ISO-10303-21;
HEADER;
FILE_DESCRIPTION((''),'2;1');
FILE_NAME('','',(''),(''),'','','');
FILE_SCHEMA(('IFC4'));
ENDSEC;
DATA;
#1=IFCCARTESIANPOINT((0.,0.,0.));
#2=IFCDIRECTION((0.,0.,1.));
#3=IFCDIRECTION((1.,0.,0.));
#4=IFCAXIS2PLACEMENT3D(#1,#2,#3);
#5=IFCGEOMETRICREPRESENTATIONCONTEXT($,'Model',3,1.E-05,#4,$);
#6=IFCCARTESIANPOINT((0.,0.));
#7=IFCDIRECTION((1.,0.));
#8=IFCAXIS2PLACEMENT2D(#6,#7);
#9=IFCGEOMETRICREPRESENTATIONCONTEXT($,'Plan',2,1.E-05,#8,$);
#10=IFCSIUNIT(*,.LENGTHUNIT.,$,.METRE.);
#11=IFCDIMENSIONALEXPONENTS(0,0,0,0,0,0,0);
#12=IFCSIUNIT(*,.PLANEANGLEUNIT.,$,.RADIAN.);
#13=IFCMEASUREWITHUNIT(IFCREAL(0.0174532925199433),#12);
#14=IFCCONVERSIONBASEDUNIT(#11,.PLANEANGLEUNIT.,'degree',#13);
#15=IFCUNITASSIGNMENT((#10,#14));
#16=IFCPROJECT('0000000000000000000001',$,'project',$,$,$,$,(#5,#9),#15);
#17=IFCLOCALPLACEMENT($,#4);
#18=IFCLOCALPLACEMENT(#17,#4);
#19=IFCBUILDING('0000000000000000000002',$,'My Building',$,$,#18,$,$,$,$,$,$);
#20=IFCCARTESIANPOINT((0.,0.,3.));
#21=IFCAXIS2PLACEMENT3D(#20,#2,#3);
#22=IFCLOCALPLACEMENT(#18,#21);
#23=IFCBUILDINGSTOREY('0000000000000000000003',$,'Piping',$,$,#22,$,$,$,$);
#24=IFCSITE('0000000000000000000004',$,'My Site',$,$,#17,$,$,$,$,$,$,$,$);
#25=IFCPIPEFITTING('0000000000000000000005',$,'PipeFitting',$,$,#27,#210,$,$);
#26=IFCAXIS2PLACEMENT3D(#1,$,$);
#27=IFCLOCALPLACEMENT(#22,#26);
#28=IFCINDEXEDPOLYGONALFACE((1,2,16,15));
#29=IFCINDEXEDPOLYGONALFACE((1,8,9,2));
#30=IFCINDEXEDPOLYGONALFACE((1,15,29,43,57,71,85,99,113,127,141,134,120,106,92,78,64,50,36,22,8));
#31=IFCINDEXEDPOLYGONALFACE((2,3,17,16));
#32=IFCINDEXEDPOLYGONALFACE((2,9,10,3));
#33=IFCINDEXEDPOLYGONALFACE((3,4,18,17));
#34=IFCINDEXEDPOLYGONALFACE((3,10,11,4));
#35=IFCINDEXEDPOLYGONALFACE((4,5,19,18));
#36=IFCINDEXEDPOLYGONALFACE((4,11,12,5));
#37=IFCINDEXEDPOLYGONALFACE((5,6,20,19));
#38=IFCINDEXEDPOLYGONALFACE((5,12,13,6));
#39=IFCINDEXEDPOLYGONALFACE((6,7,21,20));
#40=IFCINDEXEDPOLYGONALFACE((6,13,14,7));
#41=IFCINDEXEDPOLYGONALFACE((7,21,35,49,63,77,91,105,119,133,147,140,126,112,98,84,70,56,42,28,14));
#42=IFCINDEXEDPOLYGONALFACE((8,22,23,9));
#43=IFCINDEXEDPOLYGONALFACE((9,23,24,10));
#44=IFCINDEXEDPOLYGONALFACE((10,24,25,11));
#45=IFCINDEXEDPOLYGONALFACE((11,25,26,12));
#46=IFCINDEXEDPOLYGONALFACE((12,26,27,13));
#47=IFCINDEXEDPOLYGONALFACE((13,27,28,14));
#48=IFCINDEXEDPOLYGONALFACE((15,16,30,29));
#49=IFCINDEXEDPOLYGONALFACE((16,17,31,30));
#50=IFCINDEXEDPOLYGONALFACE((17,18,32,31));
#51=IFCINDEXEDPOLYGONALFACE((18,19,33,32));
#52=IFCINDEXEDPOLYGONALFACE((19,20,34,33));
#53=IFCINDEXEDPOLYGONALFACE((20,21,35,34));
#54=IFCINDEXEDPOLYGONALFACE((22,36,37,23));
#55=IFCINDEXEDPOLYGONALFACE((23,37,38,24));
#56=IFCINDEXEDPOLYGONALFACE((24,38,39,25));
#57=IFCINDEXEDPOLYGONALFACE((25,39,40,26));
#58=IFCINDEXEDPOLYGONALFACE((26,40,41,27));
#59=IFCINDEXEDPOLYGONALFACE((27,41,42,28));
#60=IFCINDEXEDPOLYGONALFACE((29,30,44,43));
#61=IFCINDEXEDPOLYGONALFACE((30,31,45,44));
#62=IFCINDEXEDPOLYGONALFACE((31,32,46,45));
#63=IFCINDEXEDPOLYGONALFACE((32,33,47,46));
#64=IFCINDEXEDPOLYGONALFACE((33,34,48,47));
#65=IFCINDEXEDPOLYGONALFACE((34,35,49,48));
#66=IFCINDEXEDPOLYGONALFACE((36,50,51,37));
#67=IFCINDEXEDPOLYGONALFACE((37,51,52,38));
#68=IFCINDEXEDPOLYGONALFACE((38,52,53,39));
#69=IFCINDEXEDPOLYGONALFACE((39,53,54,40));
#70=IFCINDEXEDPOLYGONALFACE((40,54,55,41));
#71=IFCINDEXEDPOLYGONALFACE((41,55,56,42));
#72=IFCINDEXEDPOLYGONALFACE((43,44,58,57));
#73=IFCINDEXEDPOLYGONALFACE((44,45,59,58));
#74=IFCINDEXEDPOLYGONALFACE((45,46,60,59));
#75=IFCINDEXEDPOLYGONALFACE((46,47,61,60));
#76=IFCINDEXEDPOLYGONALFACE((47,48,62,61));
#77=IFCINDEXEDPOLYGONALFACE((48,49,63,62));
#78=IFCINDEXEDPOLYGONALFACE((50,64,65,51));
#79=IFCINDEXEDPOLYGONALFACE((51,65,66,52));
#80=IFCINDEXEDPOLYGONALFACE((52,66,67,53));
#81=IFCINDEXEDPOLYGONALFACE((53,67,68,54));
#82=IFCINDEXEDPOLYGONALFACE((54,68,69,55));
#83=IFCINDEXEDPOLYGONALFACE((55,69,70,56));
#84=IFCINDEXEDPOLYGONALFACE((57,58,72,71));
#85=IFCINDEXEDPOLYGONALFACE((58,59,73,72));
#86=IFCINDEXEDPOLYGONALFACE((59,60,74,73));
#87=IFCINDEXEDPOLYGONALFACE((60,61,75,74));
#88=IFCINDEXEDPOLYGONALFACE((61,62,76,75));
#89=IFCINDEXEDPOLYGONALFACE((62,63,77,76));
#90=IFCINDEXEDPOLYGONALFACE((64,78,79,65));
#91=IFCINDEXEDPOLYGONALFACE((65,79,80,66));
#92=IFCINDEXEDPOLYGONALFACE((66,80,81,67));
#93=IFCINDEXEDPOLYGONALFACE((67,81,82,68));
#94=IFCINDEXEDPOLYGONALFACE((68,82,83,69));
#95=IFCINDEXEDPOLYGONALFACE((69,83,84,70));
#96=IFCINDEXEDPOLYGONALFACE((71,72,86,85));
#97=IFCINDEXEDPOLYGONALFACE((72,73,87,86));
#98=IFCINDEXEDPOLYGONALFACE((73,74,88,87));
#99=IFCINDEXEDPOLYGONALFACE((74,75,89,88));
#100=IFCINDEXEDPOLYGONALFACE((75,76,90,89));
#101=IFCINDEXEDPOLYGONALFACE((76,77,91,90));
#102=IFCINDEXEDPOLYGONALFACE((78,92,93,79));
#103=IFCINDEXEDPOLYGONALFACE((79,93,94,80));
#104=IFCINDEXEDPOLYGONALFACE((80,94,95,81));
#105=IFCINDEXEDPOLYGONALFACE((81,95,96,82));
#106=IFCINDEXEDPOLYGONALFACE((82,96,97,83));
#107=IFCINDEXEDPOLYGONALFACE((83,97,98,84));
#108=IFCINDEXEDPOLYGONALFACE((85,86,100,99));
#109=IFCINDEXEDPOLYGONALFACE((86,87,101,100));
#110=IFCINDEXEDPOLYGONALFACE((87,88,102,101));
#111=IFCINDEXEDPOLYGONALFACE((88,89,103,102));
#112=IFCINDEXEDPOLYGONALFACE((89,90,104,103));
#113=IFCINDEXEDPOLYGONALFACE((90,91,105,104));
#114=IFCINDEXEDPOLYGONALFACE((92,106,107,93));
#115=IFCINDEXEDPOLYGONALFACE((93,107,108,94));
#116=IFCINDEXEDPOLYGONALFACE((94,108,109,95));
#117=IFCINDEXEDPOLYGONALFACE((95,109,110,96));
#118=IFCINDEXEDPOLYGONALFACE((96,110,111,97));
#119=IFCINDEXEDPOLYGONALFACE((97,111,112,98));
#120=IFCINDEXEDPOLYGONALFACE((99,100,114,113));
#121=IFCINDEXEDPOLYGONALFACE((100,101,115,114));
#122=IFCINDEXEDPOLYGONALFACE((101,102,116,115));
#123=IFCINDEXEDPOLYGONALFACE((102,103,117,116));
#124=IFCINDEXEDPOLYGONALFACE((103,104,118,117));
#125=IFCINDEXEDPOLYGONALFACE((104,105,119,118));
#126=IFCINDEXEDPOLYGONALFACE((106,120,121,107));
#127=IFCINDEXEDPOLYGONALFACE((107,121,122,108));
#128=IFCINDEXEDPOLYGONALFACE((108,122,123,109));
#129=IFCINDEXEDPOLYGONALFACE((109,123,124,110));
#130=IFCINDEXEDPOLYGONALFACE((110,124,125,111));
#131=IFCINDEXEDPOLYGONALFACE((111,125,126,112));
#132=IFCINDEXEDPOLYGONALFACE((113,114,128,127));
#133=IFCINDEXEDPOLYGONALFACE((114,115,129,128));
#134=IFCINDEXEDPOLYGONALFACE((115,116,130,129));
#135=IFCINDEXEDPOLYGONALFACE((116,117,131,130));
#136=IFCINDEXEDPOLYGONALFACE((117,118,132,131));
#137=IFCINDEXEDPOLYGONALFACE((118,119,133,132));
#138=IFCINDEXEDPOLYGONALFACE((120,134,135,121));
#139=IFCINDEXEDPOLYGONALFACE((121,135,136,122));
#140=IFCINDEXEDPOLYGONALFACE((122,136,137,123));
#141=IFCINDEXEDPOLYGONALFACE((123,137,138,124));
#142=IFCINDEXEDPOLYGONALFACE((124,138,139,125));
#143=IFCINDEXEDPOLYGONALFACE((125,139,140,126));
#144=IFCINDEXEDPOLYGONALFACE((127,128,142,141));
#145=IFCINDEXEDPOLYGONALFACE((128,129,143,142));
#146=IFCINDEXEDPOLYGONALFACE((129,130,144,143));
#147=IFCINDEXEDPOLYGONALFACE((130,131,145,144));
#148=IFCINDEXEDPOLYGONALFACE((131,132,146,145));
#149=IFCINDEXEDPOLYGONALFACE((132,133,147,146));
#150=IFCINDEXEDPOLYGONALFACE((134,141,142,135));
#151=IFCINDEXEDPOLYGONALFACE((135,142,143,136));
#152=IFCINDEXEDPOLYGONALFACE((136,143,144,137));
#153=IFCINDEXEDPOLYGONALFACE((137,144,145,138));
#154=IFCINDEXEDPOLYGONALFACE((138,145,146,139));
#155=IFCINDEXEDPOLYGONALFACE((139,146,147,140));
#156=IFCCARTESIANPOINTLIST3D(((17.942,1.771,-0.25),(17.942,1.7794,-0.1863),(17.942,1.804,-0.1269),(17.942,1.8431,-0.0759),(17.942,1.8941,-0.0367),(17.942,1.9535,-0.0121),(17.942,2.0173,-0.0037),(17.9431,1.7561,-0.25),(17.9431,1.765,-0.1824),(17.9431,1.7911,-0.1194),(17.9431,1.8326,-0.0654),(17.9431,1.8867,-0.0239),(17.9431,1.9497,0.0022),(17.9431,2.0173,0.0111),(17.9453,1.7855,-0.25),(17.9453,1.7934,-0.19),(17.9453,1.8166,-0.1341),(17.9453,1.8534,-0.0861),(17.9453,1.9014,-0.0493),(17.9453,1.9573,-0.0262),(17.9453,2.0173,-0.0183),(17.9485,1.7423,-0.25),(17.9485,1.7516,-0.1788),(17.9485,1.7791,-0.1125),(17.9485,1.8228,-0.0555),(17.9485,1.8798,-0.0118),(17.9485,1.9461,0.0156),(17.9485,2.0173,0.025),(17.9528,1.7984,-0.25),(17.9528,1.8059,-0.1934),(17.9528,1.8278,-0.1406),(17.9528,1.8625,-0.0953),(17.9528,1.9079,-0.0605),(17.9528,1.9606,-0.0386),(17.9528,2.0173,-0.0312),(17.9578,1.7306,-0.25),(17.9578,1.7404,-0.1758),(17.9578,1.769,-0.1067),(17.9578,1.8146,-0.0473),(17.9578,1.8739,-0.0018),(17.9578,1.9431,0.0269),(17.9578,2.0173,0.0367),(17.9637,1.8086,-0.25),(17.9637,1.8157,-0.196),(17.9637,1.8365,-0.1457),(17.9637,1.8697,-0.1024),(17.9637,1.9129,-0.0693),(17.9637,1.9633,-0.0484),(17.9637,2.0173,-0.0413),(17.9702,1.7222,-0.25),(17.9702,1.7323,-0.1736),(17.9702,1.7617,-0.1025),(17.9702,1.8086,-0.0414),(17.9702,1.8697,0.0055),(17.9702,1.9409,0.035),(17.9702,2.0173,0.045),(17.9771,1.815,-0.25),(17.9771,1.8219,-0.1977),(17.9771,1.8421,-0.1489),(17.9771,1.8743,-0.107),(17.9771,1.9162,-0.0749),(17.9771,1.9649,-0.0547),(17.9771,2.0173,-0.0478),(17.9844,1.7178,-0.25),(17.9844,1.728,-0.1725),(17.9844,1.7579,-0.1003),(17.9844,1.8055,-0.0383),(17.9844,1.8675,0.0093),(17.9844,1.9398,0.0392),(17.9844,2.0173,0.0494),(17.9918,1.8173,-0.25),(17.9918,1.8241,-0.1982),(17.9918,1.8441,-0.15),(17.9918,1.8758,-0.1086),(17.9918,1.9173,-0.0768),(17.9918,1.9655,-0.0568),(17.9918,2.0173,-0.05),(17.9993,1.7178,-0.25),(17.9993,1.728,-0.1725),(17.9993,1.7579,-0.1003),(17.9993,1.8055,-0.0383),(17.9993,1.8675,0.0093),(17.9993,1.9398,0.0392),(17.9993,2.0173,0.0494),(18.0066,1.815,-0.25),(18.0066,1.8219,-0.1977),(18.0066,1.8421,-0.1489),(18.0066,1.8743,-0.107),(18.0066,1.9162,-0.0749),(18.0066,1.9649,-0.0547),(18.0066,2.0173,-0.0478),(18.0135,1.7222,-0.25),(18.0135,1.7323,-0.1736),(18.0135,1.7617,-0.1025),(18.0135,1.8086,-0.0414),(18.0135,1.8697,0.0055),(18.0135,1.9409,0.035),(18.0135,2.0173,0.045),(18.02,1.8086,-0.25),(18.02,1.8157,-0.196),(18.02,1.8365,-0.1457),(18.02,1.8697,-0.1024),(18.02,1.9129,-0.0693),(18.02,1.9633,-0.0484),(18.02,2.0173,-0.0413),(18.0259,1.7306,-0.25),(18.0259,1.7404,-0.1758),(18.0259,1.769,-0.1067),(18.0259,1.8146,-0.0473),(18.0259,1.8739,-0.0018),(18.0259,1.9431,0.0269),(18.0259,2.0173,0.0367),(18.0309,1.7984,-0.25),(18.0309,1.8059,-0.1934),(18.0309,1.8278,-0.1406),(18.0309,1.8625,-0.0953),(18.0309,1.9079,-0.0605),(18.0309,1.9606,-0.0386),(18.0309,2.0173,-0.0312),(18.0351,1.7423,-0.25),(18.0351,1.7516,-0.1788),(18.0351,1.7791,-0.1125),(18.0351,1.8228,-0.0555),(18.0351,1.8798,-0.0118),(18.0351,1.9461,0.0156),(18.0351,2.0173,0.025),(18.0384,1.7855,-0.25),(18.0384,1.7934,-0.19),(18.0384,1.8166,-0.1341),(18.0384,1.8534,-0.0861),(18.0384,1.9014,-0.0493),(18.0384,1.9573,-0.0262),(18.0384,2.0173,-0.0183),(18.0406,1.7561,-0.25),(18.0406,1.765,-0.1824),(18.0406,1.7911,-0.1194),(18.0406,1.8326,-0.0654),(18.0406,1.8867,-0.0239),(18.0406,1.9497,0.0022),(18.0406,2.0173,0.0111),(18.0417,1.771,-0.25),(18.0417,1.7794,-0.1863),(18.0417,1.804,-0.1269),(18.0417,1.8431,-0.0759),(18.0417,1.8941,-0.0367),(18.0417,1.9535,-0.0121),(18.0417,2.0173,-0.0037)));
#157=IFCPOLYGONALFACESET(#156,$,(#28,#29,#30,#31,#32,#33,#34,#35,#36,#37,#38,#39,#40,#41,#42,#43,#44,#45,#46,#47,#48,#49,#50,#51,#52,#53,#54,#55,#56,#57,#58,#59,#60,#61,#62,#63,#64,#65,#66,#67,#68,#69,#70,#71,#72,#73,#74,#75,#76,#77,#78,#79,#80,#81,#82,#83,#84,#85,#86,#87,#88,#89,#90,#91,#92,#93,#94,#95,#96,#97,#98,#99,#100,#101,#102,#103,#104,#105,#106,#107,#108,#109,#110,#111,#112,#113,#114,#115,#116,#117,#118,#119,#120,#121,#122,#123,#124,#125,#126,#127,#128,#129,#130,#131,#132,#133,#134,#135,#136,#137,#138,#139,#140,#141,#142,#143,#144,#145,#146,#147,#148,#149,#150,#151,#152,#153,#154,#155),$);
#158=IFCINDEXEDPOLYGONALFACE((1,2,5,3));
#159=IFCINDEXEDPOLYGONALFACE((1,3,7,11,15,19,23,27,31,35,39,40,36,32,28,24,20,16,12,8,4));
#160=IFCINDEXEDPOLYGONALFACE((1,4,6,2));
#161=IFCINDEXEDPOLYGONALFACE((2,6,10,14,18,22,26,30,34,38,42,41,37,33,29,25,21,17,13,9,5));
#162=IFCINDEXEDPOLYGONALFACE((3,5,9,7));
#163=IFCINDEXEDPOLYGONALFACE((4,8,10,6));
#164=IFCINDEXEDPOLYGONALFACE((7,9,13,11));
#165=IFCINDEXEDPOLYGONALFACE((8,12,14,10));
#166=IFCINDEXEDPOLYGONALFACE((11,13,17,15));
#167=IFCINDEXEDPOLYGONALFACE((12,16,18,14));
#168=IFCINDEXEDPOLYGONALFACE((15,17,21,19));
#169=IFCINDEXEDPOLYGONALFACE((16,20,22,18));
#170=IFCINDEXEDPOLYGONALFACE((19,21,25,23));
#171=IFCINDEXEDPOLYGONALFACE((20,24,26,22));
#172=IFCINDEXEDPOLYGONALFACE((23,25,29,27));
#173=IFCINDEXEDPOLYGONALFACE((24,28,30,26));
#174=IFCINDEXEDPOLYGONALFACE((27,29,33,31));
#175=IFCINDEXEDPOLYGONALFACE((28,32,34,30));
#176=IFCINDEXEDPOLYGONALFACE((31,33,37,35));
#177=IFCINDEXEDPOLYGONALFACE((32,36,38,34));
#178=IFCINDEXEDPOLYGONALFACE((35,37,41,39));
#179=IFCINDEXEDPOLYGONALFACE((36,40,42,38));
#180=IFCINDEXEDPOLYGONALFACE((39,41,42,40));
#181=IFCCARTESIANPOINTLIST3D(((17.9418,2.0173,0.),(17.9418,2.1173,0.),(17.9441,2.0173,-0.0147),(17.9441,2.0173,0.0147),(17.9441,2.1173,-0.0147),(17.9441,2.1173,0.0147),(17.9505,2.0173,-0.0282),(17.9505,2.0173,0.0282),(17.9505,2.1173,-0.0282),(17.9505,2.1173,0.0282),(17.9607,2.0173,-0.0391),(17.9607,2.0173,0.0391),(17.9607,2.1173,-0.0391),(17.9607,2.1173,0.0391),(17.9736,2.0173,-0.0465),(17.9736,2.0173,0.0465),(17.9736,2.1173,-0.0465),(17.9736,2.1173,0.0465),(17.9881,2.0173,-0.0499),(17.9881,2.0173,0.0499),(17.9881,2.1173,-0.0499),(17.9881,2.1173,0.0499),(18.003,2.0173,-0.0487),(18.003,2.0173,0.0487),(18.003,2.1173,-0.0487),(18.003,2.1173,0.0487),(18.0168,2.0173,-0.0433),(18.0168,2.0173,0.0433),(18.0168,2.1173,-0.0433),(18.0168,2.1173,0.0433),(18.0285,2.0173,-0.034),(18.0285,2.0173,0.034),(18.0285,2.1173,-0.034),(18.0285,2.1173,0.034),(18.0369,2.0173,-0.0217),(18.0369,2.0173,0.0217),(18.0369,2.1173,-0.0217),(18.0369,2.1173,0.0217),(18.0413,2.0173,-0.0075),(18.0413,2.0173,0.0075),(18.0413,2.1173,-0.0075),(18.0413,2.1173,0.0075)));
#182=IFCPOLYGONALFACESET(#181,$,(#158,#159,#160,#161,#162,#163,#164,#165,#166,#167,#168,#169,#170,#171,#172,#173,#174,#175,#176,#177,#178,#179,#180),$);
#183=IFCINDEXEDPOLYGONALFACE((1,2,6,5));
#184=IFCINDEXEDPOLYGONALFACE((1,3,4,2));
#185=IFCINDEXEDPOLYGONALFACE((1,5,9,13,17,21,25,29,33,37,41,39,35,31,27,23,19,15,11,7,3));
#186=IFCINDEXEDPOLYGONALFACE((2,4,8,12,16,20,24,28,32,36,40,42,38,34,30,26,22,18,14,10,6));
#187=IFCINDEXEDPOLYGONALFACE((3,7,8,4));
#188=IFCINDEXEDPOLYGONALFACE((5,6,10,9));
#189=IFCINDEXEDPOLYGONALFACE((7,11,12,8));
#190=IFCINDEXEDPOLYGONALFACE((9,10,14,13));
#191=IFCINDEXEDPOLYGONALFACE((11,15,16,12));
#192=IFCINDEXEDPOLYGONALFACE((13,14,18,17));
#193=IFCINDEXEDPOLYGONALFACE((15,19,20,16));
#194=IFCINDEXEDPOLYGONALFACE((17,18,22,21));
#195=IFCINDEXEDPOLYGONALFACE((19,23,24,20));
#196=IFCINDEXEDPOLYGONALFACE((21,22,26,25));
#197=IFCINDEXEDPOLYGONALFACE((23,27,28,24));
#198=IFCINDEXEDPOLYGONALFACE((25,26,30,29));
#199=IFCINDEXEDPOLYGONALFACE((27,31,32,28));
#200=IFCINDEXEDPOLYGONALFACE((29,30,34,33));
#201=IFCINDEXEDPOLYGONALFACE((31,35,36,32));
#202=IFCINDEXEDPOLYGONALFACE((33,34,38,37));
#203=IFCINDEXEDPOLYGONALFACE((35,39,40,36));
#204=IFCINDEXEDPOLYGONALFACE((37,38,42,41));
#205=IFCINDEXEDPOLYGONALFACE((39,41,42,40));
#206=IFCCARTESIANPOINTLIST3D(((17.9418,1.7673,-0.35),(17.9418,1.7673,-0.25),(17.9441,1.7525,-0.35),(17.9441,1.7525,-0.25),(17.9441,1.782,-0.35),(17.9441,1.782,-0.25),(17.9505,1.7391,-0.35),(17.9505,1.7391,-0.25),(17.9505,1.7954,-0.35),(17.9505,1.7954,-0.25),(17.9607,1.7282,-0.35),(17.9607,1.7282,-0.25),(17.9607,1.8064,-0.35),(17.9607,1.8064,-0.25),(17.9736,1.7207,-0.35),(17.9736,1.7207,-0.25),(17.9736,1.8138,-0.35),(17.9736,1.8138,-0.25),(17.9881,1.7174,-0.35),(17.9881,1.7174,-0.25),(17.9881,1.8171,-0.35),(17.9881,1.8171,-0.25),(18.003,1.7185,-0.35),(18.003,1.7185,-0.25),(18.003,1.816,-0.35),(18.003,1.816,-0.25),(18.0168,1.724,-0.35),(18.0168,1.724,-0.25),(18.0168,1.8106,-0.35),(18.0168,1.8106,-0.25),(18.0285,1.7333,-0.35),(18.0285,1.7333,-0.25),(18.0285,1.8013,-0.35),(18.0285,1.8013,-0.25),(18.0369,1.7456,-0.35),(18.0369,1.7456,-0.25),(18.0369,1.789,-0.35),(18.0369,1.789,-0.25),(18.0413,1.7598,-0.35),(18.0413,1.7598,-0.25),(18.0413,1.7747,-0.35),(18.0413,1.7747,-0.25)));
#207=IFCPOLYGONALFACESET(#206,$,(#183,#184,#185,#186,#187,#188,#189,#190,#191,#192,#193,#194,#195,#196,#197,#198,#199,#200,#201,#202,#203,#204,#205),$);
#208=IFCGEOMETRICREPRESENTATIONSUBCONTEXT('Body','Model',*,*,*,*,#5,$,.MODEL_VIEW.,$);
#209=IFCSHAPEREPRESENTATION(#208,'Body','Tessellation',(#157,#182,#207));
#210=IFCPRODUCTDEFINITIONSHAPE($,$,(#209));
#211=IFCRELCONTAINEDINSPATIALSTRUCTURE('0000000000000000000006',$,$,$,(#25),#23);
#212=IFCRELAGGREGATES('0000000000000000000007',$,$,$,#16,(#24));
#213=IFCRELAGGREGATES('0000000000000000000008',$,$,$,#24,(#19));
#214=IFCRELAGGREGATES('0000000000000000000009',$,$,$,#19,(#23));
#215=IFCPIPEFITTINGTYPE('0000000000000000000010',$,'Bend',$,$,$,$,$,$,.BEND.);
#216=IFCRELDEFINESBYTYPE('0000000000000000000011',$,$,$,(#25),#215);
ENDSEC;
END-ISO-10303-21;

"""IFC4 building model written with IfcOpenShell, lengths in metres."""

from ifc_helpers import new_model, entity, si_unit, converted_unit, frame, origin_with_axes, origin_2d_with_axis, place, context, subcontext, project, spatial, circle, extrude, source, transform, mapped, type_object, type_shapes, element, save


model = new_model("IFC4")

# Units and contexts
model_context = context("Model", 3, precision=1e-05, world=origin_with_axes())
plan_context = context("Plan", 2, precision=1e-05, world=origin_2d_with_axis())
body_context = subcontext(model_context, "Body", "Model", "MODEL_VIEW")
ifc_project = project(units=[si_unit("LENGTHUNIT", "METRE"), converted_unit("PLANEANGLEUNIT", "degree", entity("IfcReal", 0.0174532925199433), si_unit("PLANEANGLEUNIT", "RADIAN"), dimensions=[0, 0, 0, 0, 0, 0, 0])], contexts=[model_context, plan_context])

# Site, building, storey
site_placement = place(None, origin_with_axes())
site = spatial("IfcSite", under=ifc_project, at=site_placement, Name="My Site")
building_placement = place(site_placement, origin_with_axes())
building = spatial("IfcBuilding", under=site, at=building_placement, Name="My Building")
storey_placement = place(building_placement, frame((0.0, 0.0, 3.0), z_axis=(0.0, 0.0, 1.0), x_axis=(1.0, 0.0, 0.0)))
storey = spatial("IfcBuildingStorey", under=building, at=storey_placement, Name="Piping")

# Pipe fitting
pipe_fitting_type = type_object("IfcPipeFittingType", Name="Bend", PredefinedType="BEND")
shared_shape = source(origin_with_axes(), body_context, "Body", "SolidModel", [
    entity("IfcSweptDiskSolid", entity("IfcIndexedPolyCurve", entity("IfcCartesianPointList3D", [[0.0, 0.0, -0.1], [0.0, -0.0732, -0.2768], [0.0, -0.25, -0.35]]), [entity("IfcArcIndex", [1, 2, 3])]), 0.05),
    extrude(circle(Radius=0.05), origin_with_axes(), (0.0, 0.0, -1.0), 0.1),
    extrude(circle(Radius=0.05), frame((0.0, -0.25, -0.35), z_axis=(0.0, -1.0, 0.0), x_axis=(1.0, 0.0, 0.0)), (0.0, 0.0, 1.0), 0.1),
])
type_shapes(pipe_fitting_type, [shared_shape])
for number, where, z_axis, x_axis, name in (
    (1, (17.9918, 2.1173, 0.0), (0.0, 1.0, 0.0), (-1.0, 0.0, 0.0), "PipeFitting"),
):
    element("IfcPipeFitting", number, at=place(storey_placement, frame(where, z_axis=z_axis, x_axis=x_axis)), inside=storey, type_object=pipe_fitting_type, Name=name, context=body_context, shape_type="MappedRepresentation", body=[
        mapped(shared_shape, transform((0.0, 0.0, 0.0), x_axis=(1.0, 0.0, 0.0), y_axis=(0.0, 1.0, 0.0), z_axis=(0.0, 0.0, 1.0), scale=1.0)),
    ])

save(model, "model.ifc")
